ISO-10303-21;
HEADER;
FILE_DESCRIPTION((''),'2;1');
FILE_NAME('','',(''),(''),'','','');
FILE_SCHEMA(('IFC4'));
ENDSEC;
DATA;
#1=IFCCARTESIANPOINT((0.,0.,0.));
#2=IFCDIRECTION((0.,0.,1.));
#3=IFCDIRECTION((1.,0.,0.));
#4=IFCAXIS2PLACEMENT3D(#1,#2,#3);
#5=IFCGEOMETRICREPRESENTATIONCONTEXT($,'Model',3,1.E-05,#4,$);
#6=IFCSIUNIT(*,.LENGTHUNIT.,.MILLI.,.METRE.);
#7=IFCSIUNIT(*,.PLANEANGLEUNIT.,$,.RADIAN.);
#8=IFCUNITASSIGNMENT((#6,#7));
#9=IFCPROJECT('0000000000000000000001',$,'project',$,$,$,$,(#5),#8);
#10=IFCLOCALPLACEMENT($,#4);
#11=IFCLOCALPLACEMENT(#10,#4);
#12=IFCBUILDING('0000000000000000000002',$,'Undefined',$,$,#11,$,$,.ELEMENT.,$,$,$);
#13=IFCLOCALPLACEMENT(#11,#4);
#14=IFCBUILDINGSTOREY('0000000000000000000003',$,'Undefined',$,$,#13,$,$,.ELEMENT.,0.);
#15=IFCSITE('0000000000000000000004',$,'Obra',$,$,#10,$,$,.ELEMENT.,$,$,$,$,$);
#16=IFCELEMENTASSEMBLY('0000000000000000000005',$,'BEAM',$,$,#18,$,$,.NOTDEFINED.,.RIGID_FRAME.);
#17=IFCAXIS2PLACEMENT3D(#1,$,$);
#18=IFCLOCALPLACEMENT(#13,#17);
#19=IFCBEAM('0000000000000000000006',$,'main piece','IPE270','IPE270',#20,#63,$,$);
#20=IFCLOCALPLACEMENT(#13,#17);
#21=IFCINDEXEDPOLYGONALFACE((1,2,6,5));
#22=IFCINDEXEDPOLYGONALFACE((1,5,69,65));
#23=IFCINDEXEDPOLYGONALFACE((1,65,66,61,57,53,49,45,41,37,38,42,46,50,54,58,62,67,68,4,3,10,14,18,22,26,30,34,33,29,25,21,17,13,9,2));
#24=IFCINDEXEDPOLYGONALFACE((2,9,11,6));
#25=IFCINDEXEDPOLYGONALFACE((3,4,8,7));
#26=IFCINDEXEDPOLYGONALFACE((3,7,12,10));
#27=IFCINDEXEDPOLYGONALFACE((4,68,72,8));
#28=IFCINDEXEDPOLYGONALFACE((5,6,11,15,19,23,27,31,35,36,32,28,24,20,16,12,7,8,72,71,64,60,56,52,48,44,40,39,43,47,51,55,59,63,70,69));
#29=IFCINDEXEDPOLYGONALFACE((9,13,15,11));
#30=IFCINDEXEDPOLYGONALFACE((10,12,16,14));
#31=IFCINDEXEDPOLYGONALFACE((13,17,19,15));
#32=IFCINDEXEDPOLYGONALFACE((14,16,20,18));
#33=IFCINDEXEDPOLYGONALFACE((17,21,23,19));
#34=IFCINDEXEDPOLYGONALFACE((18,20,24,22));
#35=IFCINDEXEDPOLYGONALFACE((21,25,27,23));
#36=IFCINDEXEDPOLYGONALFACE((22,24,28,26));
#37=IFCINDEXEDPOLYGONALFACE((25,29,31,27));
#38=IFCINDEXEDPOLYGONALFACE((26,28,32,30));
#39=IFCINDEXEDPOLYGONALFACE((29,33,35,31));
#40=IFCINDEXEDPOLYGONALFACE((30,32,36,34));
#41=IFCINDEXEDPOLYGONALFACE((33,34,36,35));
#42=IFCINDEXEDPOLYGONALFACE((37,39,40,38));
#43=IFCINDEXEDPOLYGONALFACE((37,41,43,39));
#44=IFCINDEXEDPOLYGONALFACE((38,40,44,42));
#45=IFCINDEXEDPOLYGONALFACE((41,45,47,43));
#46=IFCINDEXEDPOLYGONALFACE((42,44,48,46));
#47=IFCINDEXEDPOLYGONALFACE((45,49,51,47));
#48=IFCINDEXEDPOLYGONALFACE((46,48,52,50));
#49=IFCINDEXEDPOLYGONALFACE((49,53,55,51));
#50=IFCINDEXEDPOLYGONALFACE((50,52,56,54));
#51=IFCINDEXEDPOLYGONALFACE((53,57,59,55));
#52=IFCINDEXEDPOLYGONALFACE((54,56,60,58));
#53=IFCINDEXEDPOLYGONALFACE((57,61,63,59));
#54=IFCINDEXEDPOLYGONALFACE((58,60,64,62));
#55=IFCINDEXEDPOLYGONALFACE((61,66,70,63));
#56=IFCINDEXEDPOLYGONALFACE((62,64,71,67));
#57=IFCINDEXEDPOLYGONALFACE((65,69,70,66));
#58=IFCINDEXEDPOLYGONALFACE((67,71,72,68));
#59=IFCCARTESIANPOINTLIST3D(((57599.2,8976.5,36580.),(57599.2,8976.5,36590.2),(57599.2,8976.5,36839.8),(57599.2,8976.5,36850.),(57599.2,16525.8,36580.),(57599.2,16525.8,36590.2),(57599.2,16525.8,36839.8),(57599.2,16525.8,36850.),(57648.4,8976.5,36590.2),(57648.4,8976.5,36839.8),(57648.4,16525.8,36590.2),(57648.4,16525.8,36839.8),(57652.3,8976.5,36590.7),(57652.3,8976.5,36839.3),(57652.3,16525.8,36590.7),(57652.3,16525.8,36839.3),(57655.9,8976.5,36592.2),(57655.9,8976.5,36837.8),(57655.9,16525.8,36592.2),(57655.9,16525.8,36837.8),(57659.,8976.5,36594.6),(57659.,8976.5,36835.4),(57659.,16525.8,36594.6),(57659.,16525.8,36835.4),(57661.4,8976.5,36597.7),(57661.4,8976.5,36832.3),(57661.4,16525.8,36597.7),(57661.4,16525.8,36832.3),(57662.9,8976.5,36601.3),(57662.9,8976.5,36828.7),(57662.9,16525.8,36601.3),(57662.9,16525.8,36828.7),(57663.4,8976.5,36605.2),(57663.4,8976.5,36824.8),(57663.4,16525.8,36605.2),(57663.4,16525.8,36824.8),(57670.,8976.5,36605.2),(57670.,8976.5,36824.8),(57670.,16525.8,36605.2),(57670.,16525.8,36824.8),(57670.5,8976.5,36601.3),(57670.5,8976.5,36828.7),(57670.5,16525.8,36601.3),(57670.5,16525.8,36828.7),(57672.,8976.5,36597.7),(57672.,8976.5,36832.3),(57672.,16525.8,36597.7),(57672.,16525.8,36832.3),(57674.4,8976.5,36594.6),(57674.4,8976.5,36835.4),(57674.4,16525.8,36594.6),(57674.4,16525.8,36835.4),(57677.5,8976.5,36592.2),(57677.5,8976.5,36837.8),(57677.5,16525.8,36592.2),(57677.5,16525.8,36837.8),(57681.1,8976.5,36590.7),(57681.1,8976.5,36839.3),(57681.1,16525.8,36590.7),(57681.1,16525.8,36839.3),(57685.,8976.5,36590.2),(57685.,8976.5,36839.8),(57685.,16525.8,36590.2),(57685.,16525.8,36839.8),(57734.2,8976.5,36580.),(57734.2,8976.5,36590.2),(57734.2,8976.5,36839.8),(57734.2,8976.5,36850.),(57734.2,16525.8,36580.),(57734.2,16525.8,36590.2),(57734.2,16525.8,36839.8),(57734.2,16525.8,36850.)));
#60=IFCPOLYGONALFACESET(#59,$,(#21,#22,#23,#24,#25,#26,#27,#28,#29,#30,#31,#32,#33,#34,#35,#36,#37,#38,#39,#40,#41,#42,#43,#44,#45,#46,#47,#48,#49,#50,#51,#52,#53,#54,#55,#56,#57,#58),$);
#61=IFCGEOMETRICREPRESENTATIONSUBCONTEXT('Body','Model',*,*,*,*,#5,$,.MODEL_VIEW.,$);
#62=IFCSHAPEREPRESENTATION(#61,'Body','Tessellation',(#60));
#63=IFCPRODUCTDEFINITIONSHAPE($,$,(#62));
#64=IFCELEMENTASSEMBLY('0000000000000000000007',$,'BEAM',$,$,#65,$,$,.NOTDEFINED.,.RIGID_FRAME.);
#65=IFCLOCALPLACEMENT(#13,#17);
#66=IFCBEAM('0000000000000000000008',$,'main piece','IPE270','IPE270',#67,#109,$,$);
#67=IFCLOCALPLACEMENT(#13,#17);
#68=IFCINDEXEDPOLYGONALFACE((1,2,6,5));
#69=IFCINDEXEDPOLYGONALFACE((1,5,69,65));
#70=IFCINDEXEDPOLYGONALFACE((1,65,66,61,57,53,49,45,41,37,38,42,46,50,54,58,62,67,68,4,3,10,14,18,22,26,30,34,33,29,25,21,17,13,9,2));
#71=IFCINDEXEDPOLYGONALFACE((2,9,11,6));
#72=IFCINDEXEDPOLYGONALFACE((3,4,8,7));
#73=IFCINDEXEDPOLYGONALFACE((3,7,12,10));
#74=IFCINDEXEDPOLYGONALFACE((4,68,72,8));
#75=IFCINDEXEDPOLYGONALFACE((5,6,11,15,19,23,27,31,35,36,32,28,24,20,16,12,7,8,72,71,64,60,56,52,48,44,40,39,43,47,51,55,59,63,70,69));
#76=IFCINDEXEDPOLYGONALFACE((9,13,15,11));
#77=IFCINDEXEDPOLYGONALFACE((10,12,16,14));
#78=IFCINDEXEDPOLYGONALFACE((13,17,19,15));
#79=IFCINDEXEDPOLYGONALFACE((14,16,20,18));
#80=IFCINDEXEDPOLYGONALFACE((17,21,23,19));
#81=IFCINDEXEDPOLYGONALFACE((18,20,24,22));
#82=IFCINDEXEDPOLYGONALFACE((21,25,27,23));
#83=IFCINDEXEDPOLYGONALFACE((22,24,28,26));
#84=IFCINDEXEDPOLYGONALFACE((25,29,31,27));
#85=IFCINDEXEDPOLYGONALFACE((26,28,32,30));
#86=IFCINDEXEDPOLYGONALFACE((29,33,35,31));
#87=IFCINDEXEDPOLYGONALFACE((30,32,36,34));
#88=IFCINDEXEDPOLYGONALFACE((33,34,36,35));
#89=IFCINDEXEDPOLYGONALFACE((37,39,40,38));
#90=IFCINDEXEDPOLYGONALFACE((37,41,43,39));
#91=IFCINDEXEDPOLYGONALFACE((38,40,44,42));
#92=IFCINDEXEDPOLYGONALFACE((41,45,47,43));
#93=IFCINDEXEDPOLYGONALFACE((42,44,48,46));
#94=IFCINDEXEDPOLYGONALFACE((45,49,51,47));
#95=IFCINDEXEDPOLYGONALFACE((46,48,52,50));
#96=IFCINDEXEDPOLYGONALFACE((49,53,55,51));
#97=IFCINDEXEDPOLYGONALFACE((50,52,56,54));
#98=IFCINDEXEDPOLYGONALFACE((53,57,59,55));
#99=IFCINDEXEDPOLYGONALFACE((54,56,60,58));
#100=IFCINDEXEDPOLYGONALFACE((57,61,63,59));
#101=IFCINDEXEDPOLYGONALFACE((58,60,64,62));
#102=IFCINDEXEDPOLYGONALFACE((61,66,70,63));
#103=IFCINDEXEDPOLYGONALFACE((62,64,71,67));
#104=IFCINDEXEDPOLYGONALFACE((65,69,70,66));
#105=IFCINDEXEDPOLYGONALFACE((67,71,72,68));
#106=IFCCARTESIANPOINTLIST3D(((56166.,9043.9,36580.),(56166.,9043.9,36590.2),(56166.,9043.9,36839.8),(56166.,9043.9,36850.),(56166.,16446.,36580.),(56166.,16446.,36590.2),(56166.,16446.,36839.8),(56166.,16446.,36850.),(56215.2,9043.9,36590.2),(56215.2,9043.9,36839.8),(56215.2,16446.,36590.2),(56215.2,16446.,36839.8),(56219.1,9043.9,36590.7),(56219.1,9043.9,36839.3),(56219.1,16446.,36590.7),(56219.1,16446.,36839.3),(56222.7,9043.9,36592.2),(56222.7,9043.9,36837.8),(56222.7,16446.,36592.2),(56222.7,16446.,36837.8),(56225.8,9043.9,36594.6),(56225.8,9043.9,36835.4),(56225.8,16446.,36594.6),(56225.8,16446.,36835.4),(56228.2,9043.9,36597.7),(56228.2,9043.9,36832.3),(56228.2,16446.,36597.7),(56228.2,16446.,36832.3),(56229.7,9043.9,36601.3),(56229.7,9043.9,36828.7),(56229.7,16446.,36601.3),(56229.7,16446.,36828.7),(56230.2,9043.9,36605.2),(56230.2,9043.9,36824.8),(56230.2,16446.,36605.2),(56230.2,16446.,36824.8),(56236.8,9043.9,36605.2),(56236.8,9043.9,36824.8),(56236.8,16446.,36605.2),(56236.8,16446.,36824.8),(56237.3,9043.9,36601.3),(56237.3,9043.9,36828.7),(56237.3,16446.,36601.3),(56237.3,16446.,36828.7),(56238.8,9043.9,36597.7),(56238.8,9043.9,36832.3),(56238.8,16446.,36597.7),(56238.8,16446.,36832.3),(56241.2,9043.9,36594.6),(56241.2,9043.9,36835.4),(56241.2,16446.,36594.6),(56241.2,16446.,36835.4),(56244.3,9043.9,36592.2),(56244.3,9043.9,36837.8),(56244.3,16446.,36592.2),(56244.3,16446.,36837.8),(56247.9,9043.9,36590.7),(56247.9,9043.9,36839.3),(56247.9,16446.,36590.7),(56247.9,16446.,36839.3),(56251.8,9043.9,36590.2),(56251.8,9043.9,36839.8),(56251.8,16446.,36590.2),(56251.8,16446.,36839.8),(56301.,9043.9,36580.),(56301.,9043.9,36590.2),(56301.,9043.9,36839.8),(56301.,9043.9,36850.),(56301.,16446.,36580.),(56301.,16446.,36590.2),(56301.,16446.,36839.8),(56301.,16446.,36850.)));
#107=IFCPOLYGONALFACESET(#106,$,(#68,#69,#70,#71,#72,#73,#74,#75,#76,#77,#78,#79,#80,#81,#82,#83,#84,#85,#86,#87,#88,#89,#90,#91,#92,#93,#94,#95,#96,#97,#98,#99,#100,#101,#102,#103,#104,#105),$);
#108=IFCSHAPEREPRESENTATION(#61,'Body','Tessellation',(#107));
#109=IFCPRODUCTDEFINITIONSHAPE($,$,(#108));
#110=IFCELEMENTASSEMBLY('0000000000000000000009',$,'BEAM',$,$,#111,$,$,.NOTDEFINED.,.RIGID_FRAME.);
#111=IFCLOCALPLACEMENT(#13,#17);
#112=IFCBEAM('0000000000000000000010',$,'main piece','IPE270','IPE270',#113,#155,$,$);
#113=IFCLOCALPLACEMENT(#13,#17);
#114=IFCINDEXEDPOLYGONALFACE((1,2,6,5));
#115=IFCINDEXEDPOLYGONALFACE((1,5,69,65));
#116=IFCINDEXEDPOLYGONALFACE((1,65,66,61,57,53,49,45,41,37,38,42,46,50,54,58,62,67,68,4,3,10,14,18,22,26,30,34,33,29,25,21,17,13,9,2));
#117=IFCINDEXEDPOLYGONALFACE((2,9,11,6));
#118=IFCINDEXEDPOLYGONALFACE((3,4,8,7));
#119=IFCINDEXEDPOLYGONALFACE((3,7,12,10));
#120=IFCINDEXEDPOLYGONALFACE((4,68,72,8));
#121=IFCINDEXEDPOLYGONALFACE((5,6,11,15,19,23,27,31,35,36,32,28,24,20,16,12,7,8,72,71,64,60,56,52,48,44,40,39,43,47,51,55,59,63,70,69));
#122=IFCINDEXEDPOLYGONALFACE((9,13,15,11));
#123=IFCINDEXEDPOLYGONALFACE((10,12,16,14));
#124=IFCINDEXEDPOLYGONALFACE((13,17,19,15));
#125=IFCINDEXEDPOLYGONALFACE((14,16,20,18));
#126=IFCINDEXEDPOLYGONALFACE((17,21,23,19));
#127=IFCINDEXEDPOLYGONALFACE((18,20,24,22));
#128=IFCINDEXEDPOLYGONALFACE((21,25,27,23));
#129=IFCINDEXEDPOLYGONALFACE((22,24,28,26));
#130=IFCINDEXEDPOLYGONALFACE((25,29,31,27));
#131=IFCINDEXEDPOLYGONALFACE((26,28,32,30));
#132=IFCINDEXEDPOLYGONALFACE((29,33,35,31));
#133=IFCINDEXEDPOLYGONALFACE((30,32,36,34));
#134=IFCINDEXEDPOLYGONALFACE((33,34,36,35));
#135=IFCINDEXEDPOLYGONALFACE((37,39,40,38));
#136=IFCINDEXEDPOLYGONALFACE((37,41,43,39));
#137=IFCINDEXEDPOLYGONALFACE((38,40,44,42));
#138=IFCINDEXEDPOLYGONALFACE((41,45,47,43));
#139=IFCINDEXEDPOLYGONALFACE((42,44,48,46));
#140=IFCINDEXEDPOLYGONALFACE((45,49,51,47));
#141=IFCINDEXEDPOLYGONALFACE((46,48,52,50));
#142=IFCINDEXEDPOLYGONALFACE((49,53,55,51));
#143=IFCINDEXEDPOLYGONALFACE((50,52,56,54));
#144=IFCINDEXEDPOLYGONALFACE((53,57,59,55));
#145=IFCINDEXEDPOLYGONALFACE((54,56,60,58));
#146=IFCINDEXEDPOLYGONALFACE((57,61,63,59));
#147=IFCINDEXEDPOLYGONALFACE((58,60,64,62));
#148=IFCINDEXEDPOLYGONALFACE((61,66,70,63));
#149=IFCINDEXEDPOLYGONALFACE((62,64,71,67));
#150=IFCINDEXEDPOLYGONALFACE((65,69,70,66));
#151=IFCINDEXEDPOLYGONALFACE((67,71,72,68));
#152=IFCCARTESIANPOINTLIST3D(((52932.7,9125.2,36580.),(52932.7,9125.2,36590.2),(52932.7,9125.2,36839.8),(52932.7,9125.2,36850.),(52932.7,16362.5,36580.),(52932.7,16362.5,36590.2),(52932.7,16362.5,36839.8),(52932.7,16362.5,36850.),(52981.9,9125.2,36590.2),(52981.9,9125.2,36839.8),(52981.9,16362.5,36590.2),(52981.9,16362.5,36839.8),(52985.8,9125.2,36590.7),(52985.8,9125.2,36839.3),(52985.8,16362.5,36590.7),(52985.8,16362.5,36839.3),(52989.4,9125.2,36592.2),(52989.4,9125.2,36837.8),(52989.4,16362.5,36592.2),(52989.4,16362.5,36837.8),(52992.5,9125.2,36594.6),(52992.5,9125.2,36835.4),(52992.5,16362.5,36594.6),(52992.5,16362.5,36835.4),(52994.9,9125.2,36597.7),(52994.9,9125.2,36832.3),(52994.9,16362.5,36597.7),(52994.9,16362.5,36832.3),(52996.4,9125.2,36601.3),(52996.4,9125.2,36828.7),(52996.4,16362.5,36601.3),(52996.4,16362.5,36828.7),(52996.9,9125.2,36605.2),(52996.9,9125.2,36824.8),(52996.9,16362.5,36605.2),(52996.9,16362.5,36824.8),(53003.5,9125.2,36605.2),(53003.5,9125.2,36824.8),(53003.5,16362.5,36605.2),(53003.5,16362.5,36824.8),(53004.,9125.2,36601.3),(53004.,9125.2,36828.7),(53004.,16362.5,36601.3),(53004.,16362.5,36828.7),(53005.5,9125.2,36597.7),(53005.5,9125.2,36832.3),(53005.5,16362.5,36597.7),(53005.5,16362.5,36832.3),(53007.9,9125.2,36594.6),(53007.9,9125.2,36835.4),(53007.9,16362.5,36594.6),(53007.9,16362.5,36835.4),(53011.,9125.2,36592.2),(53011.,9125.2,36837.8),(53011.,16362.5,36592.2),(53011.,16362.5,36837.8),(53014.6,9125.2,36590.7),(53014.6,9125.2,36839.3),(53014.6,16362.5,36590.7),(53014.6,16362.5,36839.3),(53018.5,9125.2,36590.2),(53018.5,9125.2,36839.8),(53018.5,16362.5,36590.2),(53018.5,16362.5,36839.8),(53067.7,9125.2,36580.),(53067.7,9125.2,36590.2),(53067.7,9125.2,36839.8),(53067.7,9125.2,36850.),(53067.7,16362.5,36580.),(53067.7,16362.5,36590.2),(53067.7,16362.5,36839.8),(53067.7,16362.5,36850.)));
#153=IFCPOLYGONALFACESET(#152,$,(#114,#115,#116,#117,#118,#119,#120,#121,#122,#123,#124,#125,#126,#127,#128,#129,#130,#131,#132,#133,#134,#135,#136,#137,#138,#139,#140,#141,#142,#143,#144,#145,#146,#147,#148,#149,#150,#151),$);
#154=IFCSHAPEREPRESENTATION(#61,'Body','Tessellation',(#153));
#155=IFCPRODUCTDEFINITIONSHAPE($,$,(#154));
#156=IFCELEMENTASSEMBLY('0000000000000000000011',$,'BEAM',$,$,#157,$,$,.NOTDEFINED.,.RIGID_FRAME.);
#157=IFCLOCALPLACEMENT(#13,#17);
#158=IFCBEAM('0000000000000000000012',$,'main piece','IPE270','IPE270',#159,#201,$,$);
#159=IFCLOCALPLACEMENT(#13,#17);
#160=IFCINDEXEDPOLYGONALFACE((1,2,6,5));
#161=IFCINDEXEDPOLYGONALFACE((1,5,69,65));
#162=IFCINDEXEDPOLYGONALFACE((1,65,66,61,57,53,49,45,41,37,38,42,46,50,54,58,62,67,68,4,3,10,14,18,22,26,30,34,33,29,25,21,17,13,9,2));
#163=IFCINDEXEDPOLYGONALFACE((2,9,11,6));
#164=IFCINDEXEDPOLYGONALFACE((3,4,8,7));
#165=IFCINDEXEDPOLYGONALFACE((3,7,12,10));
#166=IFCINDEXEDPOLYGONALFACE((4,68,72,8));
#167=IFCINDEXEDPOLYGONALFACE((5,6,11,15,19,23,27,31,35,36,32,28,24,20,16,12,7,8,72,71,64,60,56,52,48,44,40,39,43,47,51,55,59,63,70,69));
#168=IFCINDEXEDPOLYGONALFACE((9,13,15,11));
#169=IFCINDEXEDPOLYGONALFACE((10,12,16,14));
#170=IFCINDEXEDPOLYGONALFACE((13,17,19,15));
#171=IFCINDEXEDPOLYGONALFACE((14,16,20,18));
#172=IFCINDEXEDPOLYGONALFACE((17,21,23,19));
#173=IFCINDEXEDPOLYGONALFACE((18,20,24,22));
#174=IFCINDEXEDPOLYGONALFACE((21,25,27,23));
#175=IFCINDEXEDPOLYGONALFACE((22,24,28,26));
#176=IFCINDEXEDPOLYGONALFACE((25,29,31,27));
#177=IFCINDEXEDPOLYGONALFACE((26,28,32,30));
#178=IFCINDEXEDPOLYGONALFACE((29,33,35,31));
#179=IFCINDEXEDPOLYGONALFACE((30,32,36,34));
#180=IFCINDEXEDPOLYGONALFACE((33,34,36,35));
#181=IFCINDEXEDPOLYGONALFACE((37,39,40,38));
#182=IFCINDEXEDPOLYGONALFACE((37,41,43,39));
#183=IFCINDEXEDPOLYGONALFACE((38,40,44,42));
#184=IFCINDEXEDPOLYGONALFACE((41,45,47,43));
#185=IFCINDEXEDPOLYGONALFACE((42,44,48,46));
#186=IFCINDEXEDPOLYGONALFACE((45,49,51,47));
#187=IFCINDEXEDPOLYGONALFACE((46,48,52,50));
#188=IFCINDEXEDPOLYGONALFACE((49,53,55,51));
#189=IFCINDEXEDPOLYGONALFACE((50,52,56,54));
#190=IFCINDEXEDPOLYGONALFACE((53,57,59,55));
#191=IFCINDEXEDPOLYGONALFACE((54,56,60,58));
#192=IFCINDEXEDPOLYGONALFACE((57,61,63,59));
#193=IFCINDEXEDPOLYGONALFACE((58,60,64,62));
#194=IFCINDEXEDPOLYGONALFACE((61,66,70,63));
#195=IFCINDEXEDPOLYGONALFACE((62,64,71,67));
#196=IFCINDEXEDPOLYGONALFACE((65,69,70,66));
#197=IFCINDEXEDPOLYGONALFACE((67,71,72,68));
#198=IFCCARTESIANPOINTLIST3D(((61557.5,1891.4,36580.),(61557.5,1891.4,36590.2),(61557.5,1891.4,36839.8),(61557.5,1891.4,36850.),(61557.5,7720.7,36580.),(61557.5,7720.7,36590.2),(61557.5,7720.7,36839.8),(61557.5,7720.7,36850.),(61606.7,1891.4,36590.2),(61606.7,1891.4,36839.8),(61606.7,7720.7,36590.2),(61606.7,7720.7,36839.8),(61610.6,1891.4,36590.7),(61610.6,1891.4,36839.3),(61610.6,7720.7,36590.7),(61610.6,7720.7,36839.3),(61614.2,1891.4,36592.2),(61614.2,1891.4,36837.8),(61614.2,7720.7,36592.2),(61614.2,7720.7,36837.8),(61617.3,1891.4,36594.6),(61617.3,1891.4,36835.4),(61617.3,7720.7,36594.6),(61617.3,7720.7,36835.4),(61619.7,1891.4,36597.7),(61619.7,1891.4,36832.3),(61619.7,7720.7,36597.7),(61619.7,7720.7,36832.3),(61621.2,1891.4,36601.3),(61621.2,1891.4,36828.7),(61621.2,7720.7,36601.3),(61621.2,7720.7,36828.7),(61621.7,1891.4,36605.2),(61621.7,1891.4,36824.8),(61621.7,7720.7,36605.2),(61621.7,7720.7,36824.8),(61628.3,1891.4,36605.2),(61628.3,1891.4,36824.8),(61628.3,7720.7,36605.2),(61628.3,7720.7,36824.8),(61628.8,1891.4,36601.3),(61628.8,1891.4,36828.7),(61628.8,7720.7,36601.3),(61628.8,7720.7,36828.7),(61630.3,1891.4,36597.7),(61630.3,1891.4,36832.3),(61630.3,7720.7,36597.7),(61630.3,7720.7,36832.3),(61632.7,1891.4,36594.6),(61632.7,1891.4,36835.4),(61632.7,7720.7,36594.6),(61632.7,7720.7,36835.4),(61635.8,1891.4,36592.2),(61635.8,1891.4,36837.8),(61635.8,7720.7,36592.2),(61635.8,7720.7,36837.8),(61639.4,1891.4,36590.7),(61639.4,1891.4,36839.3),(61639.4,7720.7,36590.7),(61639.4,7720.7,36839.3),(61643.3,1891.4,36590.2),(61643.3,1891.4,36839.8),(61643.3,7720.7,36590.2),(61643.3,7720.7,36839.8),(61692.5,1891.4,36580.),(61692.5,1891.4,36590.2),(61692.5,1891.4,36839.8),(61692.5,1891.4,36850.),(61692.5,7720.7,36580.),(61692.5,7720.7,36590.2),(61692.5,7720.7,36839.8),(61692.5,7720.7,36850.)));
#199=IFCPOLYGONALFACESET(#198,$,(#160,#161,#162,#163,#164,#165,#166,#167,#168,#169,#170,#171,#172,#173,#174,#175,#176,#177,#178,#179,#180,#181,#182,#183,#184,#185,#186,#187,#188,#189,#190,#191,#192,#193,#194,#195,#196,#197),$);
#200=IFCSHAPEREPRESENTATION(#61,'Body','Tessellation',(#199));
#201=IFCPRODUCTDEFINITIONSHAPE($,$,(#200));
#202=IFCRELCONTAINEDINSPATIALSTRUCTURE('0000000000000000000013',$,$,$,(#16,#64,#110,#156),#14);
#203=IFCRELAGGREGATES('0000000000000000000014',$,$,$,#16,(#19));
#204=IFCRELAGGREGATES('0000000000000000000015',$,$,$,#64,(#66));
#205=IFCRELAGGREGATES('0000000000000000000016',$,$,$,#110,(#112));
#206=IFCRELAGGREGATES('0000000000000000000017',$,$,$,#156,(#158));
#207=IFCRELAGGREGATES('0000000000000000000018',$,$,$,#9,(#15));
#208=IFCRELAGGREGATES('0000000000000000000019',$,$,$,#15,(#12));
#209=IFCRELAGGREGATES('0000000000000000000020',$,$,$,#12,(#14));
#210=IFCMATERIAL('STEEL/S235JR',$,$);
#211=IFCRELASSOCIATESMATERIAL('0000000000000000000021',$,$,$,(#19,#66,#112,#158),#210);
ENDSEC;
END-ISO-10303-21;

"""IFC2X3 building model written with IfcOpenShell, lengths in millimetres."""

from ifc_helpers import new_model, si_unit, frame, origin_with_axes, origin_2d_with_axis, place, context, subcontext, project, spatial, i_section, extrude, material, element, aggregate, save


model = new_model("IFC2X3")

# Units and contexts
model_context = context("Model", 3, precision=1e-05, world=origin_with_axes())
body_context = subcontext(model_context, "Body", "Model", "MODEL_VIEW")
ifc_project = project(units=[si_unit("LENGTHUNIT", "METRE", prefix="MILLI"), si_unit("PLANEANGLEUNIT", "RADIAN")], contexts=[model_context])

# Site, building, storey
site_placement = place(None, origin_with_axes())
site = spatial("IfcSite", under=ifc_project, at=site_placement, Name="Obra", CompositionType="ELEMENT")
building_placement = place(site_placement, origin_with_axes())
building = spatial("IfcBuilding", under=site, at=building_placement, Name="Undefined", CompositionType="ELEMENT")
storey_placement = place(building_placement, origin_with_axes())
storey = spatial("IfcBuildingStorey", under=building, at=storey_placement, Name="Undefined", CompositionType="ELEMENT", Elevation=0.0)

# Element assemblies, beams
ifc_material_1 = material(Name="STEEL/S235JR")
assembly_1_placement = place(storey_placement, origin_with_axes())
assembly_1 = element("IfcElementAssembly", 1, at=assembly_1_placement, inside=storey, Name="BEAM", AssemblyPlace="NOTDEFINED", PredefinedType="RIGID_FRAME")
beam_1_placement = place(assembly_1_placement, frame((57666.7, 16525.8, 36715.0), z_axis=(0.0, 0.0, 1.0), x_axis=(0.0, -1.0, 0.0)))
beam_1 = element("IfcBeam", 2, at=beam_1_placement, material=ifc_material_1, Name="main piece", Description="IPE270", ObjectType="IPE270", context=body_context, shape_type="SweptSolid", body=[
    extrude(i_section(OverallWidth=135.0, OverallDepth=270.0, WebThickness=6.6, FlangeThickness=10.2, FilletRadius=15.0, at=origin_2d_with_axis()), frame((7549.3, 0.0, 0.0), z_axis=(-1.0, 0.0, 0.0), x_axis=(0.0, -1.0, 0.0)), (0.0, 0.0, 1.0), 7549.3),
])
aggregate(assembly_1, [beam_1])
assembly_2_placement = place(storey_placement, origin_with_axes())
assembly_2 = element("IfcElementAssembly", 3, at=assembly_2_placement, inside=storey, Name="BEAM", AssemblyPlace="NOTDEFINED", PredefinedType="RIGID_FRAME")
beam_2_placement = place(assembly_2_placement, frame((56233.5, 9043.9, 36715.0), z_axis=(0.0, 0.0, 1.0), x_axis=(0.0, 1.0, 0.0)))
beam_2 = element("IfcBeam", 4, at=beam_2_placement, material=ifc_material_1, Name="main piece", Description="IPE270", ObjectType="IPE270", context=body_context, shape_type="SweptSolid", body=[
    extrude(i_section(OverallWidth=135.0, OverallDepth=270.0, WebThickness=6.6, FlangeThickness=10.2, FilletRadius=15.0, at=origin_2d_with_axis()), frame((7402.1, 0.0, 0.0), z_axis=(-1.0, 0.0, 0.0), x_axis=(0.0, -1.0, 0.0)), (0.0, 0.0, 1.0), 7402.1),
])
aggregate(assembly_2, [beam_2])
assembly_3_placement = place(storey_placement, origin_with_axes())
assembly_3 = element("IfcElementAssembly", 5, at=assembly_3_placement, inside=storey, Name="BEAM", AssemblyPlace="NOTDEFINED", PredefinedType="RIGID_FRAME")
beam_3_placement = place(assembly_3_placement, frame((53000.2, 9125.2, 36715.0), z_axis=(0.0, 0.0, 1.0), x_axis=(0.000001, 1.0, 0.0)))
beam_3 = element("IfcBeam", 6, at=beam_3_placement, material=ifc_material_1, Name="main piece", Description="IPE270", ObjectType="IPE270", context=body_context, shape_type="SweptSolid", body=[
    extrude(i_section(OverallWidth=135.0, OverallDepth=270.0, WebThickness=6.6, FlangeThickness=10.2, FilletRadius=15.0, at=origin_2d_with_axis()), frame((7237.3, 0.0, 0.0), z_axis=(-1.0, 0.0, 0.0), x_axis=(0.0, -1.0, 0.0)), (0.0, 0.0, 1.0), 7237.3),
])
aggregate(assembly_3, [beam_3])
assembly_4_placement = place(storey_placement, origin_with_axes())
assembly_4 = element("IfcElementAssembly", 7, at=assembly_4_placement, inside=storey, Name="BEAM", AssemblyPlace="NOTDEFINED", PredefinedType="RIGID_FRAME")
beam_4_placement = place(assembly_4_placement, frame((61625.0, 7720.7, 36715.0), z_axis=(0.0, 0.0, 1.0), x_axis=(0.000002, -1.0, 0.0)))
beam_4 = element("IfcBeam", 8, at=beam_4_placement, material=ifc_material_1, Name="main piece", Description="IPE270", ObjectType="IPE270", context=body_context, shape_type="SweptSolid", body=[
    extrude(i_section(OverallWidth=135.0, OverallDepth=270.0, WebThickness=6.6, FlangeThickness=10.2, FilletRadius=15.0, at=origin_2d_with_axis()), frame((5829.3, 0.0, 0.0), z_axis=(-1.0, 0.0, 0.0), x_axis=(0.0, -1.0, 0.0)), (0.0, 0.0, 1.0), 5829.3),
])
aggregate(assembly_4, [beam_4])

save(model, "model.ifc")
